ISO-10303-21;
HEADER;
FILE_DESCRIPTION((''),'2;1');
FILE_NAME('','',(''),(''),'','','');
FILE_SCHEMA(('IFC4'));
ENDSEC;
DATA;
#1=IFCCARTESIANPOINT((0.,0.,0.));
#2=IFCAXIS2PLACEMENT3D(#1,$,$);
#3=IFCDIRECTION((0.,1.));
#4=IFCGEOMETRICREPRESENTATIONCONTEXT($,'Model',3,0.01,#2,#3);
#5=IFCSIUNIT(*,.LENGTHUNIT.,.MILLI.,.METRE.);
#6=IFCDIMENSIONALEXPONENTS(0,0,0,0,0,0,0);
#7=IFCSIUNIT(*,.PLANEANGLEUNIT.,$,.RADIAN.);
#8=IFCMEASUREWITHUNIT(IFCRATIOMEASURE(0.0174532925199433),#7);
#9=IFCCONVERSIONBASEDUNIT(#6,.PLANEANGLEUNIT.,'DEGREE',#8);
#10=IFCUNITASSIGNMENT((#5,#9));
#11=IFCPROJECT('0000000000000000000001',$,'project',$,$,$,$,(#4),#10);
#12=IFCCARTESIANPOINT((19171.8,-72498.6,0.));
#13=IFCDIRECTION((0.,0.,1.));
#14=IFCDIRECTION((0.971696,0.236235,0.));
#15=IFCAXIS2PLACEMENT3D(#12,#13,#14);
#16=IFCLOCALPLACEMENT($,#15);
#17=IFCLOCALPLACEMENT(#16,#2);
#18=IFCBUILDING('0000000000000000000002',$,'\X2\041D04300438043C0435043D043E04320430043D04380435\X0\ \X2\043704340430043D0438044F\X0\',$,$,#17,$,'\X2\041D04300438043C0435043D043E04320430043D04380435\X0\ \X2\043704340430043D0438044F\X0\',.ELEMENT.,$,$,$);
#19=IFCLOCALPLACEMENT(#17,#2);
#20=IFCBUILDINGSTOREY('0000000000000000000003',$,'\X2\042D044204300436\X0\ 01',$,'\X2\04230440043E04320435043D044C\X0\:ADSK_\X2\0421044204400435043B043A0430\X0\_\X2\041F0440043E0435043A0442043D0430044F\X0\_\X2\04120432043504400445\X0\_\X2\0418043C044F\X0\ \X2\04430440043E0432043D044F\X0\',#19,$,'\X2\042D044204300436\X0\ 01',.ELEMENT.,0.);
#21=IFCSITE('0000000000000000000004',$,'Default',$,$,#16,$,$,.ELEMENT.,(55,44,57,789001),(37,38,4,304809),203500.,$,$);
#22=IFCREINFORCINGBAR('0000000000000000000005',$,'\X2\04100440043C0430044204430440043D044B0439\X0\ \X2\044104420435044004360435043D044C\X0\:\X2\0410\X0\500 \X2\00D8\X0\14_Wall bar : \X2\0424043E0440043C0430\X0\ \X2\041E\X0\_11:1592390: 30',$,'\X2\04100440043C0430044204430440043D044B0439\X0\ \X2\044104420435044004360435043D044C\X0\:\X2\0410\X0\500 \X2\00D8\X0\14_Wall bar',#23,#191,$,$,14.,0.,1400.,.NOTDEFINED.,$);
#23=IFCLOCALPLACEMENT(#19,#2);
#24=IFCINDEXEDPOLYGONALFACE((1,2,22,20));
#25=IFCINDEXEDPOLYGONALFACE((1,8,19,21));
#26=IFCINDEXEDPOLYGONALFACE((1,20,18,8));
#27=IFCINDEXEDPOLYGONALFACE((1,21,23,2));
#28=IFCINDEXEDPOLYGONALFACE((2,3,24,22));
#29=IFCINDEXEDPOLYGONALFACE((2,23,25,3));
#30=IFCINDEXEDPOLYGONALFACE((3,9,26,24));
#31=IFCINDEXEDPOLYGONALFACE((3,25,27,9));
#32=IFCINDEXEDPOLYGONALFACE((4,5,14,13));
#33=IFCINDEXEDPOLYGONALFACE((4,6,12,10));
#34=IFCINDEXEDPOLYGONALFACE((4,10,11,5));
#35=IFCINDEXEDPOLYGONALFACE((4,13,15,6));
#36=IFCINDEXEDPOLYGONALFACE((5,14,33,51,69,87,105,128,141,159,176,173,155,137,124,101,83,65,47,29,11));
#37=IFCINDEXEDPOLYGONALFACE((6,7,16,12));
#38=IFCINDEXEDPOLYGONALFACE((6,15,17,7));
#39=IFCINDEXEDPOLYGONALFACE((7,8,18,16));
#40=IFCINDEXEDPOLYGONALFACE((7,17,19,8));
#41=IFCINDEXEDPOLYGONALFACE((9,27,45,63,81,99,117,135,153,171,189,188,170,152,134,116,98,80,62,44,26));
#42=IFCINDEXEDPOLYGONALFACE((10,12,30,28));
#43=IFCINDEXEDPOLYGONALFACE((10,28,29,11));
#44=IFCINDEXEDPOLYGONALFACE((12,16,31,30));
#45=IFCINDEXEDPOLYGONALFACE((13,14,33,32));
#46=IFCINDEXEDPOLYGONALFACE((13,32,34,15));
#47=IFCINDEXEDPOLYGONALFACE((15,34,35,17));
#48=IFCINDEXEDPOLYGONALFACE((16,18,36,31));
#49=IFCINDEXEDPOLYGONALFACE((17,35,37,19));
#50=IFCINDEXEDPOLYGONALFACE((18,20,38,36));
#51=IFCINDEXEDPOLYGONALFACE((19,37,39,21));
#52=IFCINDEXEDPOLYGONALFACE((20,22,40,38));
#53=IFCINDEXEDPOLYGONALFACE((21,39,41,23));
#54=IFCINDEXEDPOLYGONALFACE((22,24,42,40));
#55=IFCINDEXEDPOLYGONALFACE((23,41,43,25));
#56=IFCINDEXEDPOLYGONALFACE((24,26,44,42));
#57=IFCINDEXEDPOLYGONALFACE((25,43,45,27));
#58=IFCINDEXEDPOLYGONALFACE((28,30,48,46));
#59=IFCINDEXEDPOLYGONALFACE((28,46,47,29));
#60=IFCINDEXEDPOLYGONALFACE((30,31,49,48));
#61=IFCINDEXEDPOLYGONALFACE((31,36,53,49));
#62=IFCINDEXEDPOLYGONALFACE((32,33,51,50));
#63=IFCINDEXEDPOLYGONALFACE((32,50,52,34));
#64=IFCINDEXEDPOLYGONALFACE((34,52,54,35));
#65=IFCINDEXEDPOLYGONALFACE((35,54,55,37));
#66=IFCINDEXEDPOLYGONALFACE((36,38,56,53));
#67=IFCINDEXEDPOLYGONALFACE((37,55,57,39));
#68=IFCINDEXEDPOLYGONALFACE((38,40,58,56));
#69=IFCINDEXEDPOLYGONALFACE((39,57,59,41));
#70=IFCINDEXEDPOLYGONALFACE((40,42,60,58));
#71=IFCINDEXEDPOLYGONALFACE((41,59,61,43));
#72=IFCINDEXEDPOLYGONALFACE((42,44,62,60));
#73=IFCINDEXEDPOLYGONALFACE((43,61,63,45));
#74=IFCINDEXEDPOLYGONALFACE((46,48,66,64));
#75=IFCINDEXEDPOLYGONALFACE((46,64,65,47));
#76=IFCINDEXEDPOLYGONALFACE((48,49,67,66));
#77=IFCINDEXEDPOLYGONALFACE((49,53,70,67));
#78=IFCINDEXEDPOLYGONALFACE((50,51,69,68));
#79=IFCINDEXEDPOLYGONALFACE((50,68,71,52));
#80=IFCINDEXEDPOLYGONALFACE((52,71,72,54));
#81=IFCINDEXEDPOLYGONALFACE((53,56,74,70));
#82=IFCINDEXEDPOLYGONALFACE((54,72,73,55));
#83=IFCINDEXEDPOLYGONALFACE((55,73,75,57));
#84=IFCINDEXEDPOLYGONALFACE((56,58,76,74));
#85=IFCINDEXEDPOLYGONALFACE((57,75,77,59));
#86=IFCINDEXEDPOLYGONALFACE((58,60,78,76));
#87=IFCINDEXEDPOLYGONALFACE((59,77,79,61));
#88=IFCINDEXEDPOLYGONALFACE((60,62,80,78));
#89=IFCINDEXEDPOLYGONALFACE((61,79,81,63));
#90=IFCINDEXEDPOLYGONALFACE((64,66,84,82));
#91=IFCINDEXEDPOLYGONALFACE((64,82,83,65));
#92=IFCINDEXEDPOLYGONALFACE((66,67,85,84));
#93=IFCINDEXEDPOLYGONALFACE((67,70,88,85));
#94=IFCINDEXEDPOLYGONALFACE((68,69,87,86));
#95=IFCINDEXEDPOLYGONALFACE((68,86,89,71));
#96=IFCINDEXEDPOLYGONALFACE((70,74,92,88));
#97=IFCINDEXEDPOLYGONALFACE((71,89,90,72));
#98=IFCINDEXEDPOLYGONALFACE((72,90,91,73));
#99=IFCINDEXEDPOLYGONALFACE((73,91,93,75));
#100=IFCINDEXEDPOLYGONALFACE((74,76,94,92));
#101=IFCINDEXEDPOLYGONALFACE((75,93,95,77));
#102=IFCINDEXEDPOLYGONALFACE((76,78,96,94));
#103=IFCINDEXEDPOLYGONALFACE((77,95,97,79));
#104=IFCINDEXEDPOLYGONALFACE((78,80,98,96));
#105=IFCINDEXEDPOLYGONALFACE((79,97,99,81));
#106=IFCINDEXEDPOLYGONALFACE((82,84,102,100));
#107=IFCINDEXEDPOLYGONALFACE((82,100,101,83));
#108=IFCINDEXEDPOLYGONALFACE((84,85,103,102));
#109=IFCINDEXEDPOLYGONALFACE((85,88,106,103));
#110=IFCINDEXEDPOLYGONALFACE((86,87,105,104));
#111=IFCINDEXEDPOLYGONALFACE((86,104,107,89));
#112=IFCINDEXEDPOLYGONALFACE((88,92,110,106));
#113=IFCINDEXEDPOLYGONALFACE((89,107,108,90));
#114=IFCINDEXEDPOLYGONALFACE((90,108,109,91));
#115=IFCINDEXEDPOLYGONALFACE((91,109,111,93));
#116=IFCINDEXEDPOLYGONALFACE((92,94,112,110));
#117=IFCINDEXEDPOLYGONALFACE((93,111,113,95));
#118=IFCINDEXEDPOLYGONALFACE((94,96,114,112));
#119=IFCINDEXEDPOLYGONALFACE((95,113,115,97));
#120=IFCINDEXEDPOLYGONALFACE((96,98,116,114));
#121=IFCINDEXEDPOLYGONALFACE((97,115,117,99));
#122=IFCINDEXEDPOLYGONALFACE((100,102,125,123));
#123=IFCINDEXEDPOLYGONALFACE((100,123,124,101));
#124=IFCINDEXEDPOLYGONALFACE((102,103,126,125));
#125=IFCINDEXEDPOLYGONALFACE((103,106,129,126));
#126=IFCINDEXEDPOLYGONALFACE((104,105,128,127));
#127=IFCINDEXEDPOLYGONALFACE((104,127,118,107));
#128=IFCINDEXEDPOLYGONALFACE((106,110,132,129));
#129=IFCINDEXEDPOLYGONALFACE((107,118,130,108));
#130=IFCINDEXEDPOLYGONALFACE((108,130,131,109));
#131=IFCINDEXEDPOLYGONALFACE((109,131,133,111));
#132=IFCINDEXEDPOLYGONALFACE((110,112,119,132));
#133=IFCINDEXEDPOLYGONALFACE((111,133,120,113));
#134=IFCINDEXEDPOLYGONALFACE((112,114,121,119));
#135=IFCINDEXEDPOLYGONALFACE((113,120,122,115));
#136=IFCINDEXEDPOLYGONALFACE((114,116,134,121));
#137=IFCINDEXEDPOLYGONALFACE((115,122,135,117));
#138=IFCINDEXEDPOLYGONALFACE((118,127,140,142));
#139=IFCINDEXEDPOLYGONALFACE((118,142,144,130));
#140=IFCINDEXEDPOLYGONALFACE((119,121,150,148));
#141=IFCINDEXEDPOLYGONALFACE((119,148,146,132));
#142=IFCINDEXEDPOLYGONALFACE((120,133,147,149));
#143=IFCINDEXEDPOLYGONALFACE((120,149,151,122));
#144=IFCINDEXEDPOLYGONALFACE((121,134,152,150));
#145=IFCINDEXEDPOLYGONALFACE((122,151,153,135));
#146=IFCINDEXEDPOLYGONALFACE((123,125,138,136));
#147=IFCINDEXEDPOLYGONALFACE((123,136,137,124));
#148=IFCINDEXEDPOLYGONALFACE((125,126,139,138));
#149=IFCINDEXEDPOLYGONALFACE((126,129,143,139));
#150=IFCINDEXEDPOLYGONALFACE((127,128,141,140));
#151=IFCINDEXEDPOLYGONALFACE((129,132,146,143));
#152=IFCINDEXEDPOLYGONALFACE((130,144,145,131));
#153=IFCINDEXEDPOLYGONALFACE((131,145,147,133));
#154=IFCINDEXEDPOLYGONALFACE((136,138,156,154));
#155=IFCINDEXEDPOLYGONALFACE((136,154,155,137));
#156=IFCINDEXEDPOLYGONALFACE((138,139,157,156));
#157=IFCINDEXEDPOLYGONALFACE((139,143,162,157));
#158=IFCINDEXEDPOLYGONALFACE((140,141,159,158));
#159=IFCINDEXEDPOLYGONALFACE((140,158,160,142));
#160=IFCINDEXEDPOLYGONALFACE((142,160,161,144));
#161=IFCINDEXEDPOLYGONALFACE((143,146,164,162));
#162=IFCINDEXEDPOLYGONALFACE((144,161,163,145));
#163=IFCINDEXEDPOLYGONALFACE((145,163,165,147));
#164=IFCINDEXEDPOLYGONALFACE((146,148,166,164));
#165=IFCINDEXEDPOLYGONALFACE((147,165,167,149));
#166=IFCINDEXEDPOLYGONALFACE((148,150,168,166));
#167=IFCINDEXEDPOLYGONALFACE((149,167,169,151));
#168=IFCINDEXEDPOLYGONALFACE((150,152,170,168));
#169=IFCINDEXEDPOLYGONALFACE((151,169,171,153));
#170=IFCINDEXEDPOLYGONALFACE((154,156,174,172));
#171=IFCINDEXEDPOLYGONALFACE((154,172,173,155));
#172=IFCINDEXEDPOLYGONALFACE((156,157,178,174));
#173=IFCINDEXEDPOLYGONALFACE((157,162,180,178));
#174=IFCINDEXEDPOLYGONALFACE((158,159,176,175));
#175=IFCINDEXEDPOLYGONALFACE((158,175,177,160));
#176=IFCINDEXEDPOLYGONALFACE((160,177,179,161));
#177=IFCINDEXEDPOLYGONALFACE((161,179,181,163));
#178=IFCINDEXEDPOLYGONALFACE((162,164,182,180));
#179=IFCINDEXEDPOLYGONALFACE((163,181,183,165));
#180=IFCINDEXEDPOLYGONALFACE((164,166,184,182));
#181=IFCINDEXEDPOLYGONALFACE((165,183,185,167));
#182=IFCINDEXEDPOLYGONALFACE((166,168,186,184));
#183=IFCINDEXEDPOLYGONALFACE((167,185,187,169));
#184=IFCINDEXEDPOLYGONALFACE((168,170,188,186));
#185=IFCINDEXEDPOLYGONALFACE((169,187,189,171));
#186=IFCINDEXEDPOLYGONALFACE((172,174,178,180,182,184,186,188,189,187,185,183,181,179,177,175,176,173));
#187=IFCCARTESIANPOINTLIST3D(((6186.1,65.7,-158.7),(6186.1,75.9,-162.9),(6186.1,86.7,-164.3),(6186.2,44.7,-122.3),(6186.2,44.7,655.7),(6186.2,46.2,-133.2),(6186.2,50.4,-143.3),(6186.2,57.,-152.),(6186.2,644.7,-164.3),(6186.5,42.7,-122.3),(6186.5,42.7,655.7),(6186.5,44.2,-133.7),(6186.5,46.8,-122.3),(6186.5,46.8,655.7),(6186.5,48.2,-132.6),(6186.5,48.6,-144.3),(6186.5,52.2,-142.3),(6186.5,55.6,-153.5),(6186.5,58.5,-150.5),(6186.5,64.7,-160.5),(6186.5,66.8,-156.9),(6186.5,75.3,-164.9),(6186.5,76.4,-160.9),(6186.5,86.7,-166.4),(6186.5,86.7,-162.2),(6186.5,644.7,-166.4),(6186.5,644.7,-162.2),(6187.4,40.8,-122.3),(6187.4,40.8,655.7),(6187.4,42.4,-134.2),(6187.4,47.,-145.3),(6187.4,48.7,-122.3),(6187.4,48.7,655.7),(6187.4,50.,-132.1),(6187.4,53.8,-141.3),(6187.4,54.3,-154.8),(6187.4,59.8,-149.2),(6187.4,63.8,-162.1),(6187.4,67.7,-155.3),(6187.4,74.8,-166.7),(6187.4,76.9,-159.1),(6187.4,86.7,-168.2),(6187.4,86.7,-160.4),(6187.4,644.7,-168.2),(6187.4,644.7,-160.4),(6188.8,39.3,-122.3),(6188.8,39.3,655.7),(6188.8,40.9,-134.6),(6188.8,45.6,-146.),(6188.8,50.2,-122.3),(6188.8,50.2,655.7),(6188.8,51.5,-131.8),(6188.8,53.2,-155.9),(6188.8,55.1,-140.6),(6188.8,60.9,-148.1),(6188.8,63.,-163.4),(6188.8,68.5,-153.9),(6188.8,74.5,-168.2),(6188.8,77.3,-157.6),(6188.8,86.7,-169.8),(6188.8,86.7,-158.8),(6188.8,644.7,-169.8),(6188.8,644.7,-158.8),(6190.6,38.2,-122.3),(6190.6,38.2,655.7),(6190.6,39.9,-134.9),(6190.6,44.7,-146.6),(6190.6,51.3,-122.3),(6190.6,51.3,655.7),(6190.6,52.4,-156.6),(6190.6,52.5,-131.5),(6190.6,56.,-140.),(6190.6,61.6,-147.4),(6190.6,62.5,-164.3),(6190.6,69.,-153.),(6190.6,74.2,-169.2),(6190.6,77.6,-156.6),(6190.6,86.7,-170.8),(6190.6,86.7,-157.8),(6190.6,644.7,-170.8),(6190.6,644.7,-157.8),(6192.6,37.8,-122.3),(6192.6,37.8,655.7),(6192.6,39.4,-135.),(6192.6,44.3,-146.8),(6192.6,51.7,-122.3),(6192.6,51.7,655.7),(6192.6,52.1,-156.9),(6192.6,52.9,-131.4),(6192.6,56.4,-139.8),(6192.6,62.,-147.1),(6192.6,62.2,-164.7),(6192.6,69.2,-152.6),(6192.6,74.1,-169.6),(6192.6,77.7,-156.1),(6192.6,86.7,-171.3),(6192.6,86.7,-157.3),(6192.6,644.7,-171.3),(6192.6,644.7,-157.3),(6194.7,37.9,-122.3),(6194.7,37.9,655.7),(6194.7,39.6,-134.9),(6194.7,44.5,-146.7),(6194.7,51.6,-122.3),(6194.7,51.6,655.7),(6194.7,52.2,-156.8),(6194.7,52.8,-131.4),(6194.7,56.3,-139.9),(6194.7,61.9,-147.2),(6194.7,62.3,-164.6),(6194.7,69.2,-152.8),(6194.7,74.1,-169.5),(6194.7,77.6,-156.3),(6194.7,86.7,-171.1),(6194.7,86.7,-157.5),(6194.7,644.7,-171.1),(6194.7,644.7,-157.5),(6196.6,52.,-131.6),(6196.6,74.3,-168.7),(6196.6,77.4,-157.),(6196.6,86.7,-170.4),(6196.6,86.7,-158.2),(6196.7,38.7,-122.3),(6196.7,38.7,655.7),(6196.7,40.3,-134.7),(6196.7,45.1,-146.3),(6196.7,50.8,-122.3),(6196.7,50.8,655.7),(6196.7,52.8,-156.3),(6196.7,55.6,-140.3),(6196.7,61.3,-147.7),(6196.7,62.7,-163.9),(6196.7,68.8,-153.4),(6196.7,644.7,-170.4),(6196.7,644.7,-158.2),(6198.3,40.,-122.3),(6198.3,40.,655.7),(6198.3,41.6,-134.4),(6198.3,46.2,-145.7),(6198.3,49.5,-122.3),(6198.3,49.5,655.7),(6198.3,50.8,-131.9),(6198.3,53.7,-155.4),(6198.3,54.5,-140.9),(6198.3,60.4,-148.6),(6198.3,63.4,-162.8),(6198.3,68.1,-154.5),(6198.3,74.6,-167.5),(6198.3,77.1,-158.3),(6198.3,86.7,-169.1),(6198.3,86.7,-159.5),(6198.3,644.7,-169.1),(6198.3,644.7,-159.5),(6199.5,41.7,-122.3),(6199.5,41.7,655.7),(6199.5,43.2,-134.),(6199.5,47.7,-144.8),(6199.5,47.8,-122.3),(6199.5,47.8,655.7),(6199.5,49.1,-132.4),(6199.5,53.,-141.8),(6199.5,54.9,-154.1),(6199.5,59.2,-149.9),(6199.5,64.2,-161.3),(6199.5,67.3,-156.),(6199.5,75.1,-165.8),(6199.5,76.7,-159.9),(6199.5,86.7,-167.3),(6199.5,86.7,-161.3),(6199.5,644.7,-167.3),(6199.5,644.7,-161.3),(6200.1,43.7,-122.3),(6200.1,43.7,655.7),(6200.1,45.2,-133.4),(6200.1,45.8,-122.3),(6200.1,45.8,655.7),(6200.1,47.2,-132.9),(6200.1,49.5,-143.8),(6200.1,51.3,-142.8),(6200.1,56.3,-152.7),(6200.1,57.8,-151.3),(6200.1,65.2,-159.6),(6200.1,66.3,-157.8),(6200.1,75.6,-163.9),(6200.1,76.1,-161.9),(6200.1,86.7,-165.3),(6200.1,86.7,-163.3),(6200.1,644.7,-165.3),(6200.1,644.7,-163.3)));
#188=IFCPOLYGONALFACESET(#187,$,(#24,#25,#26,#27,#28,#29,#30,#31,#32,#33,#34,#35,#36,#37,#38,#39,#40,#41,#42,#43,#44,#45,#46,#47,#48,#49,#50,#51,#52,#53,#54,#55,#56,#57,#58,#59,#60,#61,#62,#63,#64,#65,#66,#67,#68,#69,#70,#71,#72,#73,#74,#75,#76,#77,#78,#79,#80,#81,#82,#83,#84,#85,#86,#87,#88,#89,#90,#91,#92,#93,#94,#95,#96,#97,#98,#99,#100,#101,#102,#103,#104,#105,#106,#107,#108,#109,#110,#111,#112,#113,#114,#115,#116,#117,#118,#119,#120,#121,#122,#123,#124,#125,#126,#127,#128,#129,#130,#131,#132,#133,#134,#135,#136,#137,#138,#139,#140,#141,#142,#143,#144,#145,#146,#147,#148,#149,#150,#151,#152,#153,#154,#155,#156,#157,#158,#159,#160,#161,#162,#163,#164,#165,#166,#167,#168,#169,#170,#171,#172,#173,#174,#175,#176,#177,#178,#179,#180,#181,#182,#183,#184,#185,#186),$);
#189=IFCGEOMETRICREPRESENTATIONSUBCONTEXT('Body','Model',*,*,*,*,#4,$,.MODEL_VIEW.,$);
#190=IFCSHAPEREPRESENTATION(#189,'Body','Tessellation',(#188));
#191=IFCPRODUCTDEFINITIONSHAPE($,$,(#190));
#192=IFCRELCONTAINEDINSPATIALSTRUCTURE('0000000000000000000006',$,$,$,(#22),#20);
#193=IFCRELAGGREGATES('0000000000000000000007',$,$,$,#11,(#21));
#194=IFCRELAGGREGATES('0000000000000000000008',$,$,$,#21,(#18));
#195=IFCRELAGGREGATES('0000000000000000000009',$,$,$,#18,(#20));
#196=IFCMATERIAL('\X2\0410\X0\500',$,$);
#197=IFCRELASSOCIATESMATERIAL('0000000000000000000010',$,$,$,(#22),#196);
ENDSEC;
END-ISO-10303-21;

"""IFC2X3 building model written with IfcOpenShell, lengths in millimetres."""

from ifc_helpers import new_model, entity, si_unit, converted_unit, direction, frame, origin, place, context, subcontext, project, spatial, material, element, save


model = new_model("IFC2X3")

# Units and contexts
model_context = context("Model", 3, precision=0.01, world=origin(), true_north=direction((0.0, 1.0)))
body_context = subcontext(model_context, "Body", "Model", "MODEL_VIEW")
ifc_project = project(units=[si_unit("LENGTHUNIT", "METRE", prefix="MILLI"), converted_unit("PLANEANGLEUNIT", "DEGREE", entity("IfcRatioMeasure", 0.0174532925199433), si_unit("PLANEANGLEUNIT", "RADIAN"), dimensions=[0, 0, 0, 0, 0, 0, 0])], contexts=[model_context])

# Site, building, storey
site_placement = place(None, frame((19171.8, -72498.6, 0.0), z_axis=(0.0, 0.0, 1.0), x_axis=(0.971696, 0.236235, 0.0)))
site = spatial("IfcSite", under=ifc_project, at=site_placement, Name="Default", CompositionType="ELEMENT", RefLatitude=(55, 44, 57, 789001), RefLongitude=(37, 38, 4, 304809), RefElevation=203500.0)
building_placement = place(site_placement, origin())
building = spatial("IfcBuilding", under=site, at=building_placement, Name="Наименование здания", LongName="Наименование здания", CompositionType="ELEMENT")
storey_placement = place(building_placement, origin())
storey = spatial("IfcBuildingStorey", under=building, at=storey_placement, Name="Этаж 01", ObjectType="Уровень:ADSK_Стрелка_Проектная_Вверх_Имя уровня", LongName="Этаж 01", CompositionType="ELEMENT", Elevation=0.0)

# Reinforcing bar
ifc_material = material(Name="А500")
placement = place(storey_placement, origin())
element("IfcReinforcingBar", 1, at=placement, inside=storey, material=ifc_material, Name="Арматурный стержень:А500 Ø14_Wall bar : Форма О_11:1592390: 30", ObjectType="Арматурный стержень:А500 Ø14_Wall bar", BarLength=1400.0, BarRole="NOTDEFINED", CrossSectionArea=0.0, NominalDiameter=14.0, context=body_context, shape_type="AdvancedSweptSolid", body=[
    entity("IfcSweptDiskSolid", entity("IfcCompositeCurve", [entity("IfcCompositeCurveSegment", "CONTINUOUS", True, entity("IfcPolyline", [entity("IfcCartesianPoint", [6193.1, 44.7, 655.7]), entity("IfcCartesianPoint", [6193.1, 44.7, -122.3])])), entity("IfcCompositeCurveSegment", "CONTINUOUS", True, entity("IfcTrimmedCurve", entity("IfcCircle", entity("IfcAxis2Placement3D", entity("IfcCartesianPoint", [6193.1, 86.7, -122.3]), entity("IfcDirection", [1.0, 0.0, 0.0]), entity("IfcDirection", [0.0, 0.0, -1.0])), 42.0), [entity("IfcParameterValue", 270.0)], [entity("IfcParameterValue", 360.0)], True, "PARAMETER")), entity("IfcCompositeCurveSegment", "CONTINUOUS", True, entity("IfcPolyline", [entity("IfcCartesianPoint", [6193.1, 86.7, -164.3]), entity("IfcCartesianPoint", [6193.1, 644.7, -164.3])]))], False), 7.0, None, 0.0, 92.0),
])

save(model, "model.ifc")
